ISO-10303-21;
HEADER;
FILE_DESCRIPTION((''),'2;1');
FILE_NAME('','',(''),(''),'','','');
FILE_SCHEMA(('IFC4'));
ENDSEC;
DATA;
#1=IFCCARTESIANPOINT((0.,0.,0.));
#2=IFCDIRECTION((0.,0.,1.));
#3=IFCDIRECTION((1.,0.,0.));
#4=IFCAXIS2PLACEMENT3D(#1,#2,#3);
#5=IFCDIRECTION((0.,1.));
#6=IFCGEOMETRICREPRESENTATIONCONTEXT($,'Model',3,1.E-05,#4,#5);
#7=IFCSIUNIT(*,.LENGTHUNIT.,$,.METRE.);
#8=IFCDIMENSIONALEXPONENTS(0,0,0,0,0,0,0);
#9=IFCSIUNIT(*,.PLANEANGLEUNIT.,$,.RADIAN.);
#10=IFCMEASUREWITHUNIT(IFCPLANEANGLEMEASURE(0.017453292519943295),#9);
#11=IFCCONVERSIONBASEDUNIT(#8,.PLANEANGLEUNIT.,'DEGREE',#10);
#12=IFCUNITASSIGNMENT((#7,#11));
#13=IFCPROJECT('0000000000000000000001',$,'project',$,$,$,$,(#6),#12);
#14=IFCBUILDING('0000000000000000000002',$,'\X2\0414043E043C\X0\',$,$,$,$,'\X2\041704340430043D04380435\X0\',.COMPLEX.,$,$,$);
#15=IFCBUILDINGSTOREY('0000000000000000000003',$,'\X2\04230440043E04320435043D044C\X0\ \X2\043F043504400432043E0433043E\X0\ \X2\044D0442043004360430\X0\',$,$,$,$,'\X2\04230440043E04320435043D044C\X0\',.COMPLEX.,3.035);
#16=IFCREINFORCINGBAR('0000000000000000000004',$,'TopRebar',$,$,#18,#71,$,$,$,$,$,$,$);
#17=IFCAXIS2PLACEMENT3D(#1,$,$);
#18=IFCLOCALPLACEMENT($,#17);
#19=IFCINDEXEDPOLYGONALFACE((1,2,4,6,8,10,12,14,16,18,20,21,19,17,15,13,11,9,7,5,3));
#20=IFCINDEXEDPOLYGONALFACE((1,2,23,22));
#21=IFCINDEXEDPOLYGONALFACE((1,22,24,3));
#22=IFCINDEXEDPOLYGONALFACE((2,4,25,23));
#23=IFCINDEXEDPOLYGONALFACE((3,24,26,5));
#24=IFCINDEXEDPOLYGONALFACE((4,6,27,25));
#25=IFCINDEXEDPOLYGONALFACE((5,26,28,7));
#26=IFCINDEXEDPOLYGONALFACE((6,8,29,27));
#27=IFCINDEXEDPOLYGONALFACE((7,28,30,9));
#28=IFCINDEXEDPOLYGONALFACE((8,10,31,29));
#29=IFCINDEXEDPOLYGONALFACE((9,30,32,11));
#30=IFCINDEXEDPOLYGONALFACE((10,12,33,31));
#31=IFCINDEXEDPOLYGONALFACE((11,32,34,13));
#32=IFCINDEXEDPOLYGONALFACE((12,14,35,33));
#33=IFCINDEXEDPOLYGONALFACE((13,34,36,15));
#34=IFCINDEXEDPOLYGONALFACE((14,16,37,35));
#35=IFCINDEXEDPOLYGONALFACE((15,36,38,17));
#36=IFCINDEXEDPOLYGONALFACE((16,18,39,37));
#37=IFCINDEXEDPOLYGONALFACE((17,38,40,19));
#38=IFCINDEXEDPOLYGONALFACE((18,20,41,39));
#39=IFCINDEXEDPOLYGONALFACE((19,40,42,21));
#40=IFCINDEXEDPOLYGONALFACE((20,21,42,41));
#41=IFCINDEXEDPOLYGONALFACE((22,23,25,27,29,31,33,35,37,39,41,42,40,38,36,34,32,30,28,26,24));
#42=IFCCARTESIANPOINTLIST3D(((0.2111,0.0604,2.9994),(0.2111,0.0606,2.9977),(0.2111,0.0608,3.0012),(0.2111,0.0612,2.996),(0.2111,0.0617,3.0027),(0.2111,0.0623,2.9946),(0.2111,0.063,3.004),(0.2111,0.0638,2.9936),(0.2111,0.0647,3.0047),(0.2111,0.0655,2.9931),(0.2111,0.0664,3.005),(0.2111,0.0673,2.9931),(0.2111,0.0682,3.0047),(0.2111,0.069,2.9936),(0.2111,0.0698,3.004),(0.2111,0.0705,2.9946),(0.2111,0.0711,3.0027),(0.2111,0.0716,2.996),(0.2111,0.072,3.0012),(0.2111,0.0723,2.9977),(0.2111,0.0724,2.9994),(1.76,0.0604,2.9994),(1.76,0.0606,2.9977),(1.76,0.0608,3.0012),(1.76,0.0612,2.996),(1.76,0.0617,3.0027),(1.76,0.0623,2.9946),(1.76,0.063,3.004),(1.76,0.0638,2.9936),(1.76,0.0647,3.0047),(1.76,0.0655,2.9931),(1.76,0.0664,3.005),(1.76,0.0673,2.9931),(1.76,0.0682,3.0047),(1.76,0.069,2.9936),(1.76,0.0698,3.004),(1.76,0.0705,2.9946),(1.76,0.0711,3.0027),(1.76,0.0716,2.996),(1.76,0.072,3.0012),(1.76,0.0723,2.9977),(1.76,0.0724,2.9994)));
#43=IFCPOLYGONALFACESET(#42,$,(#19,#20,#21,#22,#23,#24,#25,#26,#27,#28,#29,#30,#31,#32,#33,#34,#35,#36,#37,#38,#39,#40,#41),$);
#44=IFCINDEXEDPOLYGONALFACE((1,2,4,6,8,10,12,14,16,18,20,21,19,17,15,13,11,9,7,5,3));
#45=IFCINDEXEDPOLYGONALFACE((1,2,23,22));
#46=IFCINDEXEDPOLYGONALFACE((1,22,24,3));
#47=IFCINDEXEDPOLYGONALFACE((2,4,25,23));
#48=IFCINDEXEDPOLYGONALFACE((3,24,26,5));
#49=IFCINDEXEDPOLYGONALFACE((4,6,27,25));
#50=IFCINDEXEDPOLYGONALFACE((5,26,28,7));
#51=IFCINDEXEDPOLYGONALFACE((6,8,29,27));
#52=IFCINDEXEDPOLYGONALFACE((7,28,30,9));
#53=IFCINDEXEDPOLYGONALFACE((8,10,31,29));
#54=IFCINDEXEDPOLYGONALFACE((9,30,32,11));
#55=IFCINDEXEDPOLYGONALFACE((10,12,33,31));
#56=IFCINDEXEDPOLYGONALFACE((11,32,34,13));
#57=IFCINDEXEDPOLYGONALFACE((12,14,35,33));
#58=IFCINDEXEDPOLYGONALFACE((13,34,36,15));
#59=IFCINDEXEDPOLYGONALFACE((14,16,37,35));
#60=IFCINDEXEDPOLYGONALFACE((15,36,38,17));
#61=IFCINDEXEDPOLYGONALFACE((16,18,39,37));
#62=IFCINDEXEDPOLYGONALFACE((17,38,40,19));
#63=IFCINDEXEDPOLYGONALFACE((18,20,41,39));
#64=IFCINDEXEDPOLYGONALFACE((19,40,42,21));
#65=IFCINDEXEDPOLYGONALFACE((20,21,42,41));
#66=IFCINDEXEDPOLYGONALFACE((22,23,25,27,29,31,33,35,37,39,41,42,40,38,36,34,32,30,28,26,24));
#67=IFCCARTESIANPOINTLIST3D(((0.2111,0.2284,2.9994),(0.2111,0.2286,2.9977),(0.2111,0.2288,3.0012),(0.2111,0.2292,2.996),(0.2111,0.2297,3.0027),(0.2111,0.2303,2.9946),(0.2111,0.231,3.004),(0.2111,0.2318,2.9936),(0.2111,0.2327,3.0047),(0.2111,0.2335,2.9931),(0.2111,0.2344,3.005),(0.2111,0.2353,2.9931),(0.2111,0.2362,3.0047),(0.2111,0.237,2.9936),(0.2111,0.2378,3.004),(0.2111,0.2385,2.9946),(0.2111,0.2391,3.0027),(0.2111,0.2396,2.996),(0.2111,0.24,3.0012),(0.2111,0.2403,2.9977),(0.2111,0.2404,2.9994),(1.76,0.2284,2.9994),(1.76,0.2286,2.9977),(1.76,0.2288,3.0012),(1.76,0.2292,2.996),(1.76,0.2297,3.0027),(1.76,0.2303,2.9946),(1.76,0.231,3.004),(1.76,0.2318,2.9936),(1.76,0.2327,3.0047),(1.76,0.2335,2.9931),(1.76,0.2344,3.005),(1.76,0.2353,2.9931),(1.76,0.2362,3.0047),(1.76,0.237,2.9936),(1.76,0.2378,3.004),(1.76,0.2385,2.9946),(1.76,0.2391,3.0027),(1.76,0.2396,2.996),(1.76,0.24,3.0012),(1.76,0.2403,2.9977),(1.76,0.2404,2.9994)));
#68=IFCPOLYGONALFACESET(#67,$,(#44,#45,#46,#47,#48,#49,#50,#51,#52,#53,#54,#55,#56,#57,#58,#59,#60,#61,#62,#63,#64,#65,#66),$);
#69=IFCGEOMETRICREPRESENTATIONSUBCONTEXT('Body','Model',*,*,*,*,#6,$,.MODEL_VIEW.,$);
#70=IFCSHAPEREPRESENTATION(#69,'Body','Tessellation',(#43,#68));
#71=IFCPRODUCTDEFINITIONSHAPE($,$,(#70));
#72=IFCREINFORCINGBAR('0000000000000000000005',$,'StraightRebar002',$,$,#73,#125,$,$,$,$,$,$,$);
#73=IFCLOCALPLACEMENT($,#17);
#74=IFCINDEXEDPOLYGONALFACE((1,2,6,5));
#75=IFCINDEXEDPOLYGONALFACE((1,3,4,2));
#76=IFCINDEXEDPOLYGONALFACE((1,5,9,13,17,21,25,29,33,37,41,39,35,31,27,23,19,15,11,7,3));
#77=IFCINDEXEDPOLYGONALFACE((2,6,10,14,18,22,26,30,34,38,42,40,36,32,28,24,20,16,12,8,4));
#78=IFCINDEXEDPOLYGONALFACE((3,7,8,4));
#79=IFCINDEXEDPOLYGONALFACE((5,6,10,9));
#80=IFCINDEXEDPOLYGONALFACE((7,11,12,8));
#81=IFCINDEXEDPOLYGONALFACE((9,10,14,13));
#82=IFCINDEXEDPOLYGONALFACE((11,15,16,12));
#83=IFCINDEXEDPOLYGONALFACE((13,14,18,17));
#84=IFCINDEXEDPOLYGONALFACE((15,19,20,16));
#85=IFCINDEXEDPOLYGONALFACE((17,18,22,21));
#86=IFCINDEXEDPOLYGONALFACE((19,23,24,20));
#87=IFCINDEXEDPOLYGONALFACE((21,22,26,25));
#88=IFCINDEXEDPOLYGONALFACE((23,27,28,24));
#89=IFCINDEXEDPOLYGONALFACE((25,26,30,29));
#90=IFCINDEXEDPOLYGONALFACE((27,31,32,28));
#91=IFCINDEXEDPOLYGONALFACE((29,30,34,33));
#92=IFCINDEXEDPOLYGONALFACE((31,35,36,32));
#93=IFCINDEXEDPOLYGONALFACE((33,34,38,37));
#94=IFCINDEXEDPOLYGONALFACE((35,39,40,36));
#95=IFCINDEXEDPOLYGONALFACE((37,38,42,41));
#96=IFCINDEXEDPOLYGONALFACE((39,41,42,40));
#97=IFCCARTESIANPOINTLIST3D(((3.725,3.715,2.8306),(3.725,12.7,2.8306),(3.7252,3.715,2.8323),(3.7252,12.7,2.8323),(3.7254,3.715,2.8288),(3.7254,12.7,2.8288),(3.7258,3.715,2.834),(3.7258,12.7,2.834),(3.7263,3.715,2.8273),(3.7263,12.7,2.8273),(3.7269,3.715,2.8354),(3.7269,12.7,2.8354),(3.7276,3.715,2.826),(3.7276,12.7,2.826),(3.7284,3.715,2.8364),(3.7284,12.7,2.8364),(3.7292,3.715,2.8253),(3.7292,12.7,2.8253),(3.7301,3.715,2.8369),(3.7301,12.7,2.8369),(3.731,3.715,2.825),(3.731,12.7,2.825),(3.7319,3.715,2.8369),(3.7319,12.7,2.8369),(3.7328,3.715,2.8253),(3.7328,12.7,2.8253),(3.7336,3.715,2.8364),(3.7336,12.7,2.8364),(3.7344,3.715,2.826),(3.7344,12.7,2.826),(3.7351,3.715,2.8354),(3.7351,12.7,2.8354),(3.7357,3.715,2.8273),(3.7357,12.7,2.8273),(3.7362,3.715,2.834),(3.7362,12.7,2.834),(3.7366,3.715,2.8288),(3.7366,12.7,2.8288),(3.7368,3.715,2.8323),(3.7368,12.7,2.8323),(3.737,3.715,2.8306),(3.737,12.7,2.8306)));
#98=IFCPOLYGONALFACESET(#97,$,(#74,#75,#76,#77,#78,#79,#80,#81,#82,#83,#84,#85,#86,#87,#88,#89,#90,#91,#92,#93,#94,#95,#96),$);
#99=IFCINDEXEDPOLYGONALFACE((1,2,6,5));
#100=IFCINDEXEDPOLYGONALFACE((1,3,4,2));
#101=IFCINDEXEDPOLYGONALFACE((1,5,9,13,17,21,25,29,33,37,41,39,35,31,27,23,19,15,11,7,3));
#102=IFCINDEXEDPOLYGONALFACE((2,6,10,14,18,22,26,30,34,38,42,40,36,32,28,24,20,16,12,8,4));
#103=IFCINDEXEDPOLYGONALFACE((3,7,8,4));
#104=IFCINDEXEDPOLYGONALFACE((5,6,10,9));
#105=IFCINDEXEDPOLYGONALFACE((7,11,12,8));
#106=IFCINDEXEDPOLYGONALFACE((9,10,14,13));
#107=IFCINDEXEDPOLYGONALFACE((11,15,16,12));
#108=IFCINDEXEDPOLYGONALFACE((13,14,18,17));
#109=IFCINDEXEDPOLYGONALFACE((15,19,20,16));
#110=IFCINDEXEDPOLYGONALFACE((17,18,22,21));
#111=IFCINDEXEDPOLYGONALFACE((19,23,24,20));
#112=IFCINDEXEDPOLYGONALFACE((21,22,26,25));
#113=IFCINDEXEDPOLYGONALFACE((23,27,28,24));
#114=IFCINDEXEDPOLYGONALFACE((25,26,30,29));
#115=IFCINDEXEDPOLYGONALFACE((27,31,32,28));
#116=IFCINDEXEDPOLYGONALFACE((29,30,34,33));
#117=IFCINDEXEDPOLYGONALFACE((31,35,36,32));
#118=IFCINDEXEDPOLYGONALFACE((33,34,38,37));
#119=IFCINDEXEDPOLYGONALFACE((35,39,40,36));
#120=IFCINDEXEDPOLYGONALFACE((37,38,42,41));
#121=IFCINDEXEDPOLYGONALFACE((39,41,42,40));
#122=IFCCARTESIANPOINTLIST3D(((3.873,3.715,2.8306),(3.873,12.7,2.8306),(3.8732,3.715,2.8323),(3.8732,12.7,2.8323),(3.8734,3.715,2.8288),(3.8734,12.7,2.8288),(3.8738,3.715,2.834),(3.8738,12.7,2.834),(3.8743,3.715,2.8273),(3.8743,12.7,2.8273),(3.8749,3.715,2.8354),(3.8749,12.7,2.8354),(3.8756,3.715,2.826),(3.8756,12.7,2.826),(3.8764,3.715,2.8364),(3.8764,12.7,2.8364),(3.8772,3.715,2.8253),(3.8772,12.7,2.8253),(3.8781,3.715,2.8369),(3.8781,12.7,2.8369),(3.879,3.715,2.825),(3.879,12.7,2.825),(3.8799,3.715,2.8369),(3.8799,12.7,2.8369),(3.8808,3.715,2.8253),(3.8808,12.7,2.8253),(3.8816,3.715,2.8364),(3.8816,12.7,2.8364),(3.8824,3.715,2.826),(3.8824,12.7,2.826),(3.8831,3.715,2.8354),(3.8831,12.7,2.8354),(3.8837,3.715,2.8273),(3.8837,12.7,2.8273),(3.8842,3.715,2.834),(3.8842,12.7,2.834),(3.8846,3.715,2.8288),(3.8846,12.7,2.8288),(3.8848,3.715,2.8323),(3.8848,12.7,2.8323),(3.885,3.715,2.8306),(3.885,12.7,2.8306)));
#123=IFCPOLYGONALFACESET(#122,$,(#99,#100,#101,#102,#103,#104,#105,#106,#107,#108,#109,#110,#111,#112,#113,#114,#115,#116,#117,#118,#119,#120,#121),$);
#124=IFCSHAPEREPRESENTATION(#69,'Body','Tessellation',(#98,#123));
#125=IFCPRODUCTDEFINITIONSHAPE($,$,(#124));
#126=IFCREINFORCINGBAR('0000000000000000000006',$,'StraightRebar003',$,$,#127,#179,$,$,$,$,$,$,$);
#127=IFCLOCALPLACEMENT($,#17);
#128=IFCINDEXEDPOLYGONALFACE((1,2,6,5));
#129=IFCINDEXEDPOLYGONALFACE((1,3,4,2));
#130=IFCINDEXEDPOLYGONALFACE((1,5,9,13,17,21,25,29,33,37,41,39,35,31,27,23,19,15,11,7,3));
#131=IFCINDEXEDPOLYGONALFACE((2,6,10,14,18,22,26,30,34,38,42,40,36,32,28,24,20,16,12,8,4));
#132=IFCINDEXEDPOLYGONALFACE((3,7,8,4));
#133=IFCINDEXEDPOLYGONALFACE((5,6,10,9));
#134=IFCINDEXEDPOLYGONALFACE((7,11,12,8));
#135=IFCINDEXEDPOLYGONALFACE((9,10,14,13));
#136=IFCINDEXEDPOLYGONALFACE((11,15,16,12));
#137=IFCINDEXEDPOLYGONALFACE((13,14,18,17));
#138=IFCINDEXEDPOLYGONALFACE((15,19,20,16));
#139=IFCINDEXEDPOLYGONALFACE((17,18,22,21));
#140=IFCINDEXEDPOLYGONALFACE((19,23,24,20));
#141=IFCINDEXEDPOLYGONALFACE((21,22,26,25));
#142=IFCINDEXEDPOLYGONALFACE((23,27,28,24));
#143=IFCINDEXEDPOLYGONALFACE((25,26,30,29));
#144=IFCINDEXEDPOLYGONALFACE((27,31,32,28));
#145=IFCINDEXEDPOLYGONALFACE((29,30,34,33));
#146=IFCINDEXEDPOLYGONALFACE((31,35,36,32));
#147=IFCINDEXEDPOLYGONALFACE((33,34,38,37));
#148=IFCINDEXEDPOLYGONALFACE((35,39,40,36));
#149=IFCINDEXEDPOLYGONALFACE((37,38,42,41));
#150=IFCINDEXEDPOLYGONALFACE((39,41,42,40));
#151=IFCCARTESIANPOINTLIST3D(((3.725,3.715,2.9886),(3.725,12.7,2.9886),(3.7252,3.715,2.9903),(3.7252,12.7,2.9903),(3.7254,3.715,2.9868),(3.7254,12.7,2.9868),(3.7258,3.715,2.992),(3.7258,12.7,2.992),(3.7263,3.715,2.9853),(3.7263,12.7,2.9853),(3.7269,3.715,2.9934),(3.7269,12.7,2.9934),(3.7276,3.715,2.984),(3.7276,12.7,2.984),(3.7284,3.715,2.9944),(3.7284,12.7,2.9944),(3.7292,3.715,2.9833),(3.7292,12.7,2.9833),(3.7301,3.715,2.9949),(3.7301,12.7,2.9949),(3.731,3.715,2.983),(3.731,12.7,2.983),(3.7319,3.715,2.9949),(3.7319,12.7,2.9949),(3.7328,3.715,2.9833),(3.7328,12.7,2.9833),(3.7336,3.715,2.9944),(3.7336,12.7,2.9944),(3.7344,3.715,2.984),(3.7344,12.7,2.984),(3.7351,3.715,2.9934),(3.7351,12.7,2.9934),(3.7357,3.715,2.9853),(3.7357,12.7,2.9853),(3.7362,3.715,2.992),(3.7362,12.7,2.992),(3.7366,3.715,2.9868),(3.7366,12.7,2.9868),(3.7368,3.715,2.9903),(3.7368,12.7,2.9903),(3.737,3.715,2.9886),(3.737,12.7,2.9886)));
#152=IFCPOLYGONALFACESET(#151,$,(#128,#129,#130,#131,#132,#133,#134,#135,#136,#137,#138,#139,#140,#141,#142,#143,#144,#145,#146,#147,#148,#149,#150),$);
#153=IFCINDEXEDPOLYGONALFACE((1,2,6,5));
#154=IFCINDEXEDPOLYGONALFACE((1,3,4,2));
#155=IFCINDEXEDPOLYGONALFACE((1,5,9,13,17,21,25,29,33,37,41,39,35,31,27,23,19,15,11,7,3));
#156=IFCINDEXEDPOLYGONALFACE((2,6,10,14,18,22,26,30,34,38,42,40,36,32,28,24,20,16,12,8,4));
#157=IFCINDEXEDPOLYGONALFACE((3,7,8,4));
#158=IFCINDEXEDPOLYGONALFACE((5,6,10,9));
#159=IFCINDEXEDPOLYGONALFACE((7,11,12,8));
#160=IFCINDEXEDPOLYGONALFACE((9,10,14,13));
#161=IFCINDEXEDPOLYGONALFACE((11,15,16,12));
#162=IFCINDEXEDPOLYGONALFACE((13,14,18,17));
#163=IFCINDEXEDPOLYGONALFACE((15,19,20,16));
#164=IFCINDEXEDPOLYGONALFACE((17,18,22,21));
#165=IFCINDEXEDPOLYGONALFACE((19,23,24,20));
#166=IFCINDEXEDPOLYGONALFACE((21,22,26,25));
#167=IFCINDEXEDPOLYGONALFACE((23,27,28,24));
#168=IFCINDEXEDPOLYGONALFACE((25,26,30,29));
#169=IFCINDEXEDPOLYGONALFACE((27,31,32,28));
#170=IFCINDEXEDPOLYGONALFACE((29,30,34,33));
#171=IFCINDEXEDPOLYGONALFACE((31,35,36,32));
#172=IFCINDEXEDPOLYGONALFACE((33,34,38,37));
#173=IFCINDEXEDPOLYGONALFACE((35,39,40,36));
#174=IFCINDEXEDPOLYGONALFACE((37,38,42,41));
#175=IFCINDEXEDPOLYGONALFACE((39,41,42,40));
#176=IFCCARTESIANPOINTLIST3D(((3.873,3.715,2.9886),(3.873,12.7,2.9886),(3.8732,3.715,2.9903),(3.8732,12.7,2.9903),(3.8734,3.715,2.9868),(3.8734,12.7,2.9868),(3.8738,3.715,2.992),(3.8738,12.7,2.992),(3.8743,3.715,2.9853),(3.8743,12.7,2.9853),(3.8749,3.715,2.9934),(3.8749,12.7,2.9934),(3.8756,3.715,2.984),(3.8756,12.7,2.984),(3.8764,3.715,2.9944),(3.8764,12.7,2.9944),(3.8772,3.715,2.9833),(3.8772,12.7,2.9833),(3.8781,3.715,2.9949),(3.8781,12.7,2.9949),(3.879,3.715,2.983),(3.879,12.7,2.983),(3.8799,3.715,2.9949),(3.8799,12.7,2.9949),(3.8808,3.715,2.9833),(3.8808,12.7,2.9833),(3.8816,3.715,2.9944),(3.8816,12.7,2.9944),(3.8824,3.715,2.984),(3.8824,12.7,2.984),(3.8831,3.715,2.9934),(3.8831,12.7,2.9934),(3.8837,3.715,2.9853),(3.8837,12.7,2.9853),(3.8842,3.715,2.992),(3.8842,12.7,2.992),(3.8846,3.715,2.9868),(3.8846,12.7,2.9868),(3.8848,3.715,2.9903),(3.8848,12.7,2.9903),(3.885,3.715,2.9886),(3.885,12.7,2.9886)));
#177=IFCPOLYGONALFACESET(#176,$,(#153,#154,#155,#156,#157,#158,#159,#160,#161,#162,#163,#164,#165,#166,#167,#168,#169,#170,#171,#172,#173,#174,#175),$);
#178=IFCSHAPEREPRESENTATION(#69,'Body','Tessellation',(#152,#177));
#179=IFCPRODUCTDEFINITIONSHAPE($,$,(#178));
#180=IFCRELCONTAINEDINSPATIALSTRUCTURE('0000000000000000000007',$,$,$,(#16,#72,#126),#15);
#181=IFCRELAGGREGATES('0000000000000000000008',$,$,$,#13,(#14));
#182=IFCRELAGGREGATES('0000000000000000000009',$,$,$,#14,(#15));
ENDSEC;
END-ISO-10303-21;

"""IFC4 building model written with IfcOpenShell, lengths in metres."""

from ifc_helpers import new_model, entity, si_unit, converted_unit, direction, origin_with_axes, place, context, subcontext, project, spatial, element, save


model = new_model("IFC4")

# Units and contexts
model_context = context("Model", 3, precision=1e-05, world=origin_with_axes(), true_north=direction((0.0, 1.0)))
body_context = subcontext(model_context, "Body", "Model", "MODEL_VIEW")
ifc_project = project(units=[si_unit("LENGTHUNIT", "METRE"), converted_unit("PLANEANGLEUNIT", "DEGREE", entity("IfcPlaneAngleMeasure", 0.017453292519943295), si_unit("PLANEANGLEUNIT", "RADIAN"), dimensions=[0, 0, 0, 0, 0, 0, 0])], contexts=[model_context])

# Building, storey
building = spatial("IfcBuilding", under=ifc_project, Name="Дом", LongName="Здание", CompositionType="COMPLEX")
storey = spatial("IfcBuildingStorey", under=building, Name="Уровень первого этажа", LongName="Уровень", CompositionType="COMPLEX", Elevation=3.035)

# Shared definitions
placement = place(None, origin_with_axes())

# Reinforcing bars
element("IfcReinforcingBar", 1, at=placement, inside=storey, Name="TopRebar", context=body_context, shape_type="SweptSolid", body=[
    entity("IfcSweptDiskSolid", entity("IfcCompositeCurve", [entity("IfcCompositeCurveSegment", "CONTINUOUS", True, entity("IfcPolyline", [entity("IfcCartesianPoint", [0.2111, 0.0664, 2.999]), entity("IfcCartesianPoint", [1.76, 0.0664, 2.999])]))], False), 0.006),
    entity("IfcSweptDiskSolid", entity("IfcCompositeCurve", [entity("IfcCompositeCurveSegment", "CONTINUOUS", True, entity("IfcPolyline", [entity("IfcCartesianPoint", [0.2111, 0.2344, 2.999]), entity("IfcCartesianPoint", [1.76, 0.2344, 2.999])]))], False), 0.006),
])
element("IfcReinforcingBar", 2, at=placement, inside=storey, Name="StraightRebar002", context=body_context, shape_type="SweptSolid", body=[
    entity("IfcSweptDiskSolid", entity("IfcCompositeCurve", [entity("IfcCompositeCurveSegment", "CONTINUOUS", True, entity("IfcPolyline", [entity("IfcCartesianPoint", [3.731, 12.7, 2.831]), entity("IfcCartesianPoint", [3.731, 3.715, 2.831])]))], False), 0.006),
    entity("IfcSweptDiskSolid", entity("IfcCompositeCurve", [entity("IfcCompositeCurveSegment", "CONTINUOUS", True, entity("IfcPolyline", [entity("IfcCartesianPoint", [3.879, 12.7, 2.831]), entity("IfcCartesianPoint", [3.879, 3.715, 2.831])]))], False), 0.006),
])
element("IfcReinforcingBar", 3, at=placement, inside=storey, Name="StraightRebar003", context=body_context, shape_type="SweptSolid", body=[
    entity("IfcSweptDiskSolid", entity("IfcCompositeCurve", [entity("IfcCompositeCurveSegment", "CONTINUOUS", True, entity("IfcPolyline", [entity("IfcCartesianPoint", [3.731, 12.7, 2.989]), entity("IfcCartesianPoint", [3.731, 3.715, 2.989])]))], False), 0.006),
    entity("IfcSweptDiskSolid", entity("IfcCompositeCurve", [entity("IfcCompositeCurveSegment", "CONTINUOUS", True, entity("IfcPolyline", [entity("IfcCartesianPoint", [3.879, 12.7, 2.989]), entity("IfcCartesianPoint", [3.879, 3.715, 2.989])]))], False), 0.006),
])

save(model, "model.ifc")
